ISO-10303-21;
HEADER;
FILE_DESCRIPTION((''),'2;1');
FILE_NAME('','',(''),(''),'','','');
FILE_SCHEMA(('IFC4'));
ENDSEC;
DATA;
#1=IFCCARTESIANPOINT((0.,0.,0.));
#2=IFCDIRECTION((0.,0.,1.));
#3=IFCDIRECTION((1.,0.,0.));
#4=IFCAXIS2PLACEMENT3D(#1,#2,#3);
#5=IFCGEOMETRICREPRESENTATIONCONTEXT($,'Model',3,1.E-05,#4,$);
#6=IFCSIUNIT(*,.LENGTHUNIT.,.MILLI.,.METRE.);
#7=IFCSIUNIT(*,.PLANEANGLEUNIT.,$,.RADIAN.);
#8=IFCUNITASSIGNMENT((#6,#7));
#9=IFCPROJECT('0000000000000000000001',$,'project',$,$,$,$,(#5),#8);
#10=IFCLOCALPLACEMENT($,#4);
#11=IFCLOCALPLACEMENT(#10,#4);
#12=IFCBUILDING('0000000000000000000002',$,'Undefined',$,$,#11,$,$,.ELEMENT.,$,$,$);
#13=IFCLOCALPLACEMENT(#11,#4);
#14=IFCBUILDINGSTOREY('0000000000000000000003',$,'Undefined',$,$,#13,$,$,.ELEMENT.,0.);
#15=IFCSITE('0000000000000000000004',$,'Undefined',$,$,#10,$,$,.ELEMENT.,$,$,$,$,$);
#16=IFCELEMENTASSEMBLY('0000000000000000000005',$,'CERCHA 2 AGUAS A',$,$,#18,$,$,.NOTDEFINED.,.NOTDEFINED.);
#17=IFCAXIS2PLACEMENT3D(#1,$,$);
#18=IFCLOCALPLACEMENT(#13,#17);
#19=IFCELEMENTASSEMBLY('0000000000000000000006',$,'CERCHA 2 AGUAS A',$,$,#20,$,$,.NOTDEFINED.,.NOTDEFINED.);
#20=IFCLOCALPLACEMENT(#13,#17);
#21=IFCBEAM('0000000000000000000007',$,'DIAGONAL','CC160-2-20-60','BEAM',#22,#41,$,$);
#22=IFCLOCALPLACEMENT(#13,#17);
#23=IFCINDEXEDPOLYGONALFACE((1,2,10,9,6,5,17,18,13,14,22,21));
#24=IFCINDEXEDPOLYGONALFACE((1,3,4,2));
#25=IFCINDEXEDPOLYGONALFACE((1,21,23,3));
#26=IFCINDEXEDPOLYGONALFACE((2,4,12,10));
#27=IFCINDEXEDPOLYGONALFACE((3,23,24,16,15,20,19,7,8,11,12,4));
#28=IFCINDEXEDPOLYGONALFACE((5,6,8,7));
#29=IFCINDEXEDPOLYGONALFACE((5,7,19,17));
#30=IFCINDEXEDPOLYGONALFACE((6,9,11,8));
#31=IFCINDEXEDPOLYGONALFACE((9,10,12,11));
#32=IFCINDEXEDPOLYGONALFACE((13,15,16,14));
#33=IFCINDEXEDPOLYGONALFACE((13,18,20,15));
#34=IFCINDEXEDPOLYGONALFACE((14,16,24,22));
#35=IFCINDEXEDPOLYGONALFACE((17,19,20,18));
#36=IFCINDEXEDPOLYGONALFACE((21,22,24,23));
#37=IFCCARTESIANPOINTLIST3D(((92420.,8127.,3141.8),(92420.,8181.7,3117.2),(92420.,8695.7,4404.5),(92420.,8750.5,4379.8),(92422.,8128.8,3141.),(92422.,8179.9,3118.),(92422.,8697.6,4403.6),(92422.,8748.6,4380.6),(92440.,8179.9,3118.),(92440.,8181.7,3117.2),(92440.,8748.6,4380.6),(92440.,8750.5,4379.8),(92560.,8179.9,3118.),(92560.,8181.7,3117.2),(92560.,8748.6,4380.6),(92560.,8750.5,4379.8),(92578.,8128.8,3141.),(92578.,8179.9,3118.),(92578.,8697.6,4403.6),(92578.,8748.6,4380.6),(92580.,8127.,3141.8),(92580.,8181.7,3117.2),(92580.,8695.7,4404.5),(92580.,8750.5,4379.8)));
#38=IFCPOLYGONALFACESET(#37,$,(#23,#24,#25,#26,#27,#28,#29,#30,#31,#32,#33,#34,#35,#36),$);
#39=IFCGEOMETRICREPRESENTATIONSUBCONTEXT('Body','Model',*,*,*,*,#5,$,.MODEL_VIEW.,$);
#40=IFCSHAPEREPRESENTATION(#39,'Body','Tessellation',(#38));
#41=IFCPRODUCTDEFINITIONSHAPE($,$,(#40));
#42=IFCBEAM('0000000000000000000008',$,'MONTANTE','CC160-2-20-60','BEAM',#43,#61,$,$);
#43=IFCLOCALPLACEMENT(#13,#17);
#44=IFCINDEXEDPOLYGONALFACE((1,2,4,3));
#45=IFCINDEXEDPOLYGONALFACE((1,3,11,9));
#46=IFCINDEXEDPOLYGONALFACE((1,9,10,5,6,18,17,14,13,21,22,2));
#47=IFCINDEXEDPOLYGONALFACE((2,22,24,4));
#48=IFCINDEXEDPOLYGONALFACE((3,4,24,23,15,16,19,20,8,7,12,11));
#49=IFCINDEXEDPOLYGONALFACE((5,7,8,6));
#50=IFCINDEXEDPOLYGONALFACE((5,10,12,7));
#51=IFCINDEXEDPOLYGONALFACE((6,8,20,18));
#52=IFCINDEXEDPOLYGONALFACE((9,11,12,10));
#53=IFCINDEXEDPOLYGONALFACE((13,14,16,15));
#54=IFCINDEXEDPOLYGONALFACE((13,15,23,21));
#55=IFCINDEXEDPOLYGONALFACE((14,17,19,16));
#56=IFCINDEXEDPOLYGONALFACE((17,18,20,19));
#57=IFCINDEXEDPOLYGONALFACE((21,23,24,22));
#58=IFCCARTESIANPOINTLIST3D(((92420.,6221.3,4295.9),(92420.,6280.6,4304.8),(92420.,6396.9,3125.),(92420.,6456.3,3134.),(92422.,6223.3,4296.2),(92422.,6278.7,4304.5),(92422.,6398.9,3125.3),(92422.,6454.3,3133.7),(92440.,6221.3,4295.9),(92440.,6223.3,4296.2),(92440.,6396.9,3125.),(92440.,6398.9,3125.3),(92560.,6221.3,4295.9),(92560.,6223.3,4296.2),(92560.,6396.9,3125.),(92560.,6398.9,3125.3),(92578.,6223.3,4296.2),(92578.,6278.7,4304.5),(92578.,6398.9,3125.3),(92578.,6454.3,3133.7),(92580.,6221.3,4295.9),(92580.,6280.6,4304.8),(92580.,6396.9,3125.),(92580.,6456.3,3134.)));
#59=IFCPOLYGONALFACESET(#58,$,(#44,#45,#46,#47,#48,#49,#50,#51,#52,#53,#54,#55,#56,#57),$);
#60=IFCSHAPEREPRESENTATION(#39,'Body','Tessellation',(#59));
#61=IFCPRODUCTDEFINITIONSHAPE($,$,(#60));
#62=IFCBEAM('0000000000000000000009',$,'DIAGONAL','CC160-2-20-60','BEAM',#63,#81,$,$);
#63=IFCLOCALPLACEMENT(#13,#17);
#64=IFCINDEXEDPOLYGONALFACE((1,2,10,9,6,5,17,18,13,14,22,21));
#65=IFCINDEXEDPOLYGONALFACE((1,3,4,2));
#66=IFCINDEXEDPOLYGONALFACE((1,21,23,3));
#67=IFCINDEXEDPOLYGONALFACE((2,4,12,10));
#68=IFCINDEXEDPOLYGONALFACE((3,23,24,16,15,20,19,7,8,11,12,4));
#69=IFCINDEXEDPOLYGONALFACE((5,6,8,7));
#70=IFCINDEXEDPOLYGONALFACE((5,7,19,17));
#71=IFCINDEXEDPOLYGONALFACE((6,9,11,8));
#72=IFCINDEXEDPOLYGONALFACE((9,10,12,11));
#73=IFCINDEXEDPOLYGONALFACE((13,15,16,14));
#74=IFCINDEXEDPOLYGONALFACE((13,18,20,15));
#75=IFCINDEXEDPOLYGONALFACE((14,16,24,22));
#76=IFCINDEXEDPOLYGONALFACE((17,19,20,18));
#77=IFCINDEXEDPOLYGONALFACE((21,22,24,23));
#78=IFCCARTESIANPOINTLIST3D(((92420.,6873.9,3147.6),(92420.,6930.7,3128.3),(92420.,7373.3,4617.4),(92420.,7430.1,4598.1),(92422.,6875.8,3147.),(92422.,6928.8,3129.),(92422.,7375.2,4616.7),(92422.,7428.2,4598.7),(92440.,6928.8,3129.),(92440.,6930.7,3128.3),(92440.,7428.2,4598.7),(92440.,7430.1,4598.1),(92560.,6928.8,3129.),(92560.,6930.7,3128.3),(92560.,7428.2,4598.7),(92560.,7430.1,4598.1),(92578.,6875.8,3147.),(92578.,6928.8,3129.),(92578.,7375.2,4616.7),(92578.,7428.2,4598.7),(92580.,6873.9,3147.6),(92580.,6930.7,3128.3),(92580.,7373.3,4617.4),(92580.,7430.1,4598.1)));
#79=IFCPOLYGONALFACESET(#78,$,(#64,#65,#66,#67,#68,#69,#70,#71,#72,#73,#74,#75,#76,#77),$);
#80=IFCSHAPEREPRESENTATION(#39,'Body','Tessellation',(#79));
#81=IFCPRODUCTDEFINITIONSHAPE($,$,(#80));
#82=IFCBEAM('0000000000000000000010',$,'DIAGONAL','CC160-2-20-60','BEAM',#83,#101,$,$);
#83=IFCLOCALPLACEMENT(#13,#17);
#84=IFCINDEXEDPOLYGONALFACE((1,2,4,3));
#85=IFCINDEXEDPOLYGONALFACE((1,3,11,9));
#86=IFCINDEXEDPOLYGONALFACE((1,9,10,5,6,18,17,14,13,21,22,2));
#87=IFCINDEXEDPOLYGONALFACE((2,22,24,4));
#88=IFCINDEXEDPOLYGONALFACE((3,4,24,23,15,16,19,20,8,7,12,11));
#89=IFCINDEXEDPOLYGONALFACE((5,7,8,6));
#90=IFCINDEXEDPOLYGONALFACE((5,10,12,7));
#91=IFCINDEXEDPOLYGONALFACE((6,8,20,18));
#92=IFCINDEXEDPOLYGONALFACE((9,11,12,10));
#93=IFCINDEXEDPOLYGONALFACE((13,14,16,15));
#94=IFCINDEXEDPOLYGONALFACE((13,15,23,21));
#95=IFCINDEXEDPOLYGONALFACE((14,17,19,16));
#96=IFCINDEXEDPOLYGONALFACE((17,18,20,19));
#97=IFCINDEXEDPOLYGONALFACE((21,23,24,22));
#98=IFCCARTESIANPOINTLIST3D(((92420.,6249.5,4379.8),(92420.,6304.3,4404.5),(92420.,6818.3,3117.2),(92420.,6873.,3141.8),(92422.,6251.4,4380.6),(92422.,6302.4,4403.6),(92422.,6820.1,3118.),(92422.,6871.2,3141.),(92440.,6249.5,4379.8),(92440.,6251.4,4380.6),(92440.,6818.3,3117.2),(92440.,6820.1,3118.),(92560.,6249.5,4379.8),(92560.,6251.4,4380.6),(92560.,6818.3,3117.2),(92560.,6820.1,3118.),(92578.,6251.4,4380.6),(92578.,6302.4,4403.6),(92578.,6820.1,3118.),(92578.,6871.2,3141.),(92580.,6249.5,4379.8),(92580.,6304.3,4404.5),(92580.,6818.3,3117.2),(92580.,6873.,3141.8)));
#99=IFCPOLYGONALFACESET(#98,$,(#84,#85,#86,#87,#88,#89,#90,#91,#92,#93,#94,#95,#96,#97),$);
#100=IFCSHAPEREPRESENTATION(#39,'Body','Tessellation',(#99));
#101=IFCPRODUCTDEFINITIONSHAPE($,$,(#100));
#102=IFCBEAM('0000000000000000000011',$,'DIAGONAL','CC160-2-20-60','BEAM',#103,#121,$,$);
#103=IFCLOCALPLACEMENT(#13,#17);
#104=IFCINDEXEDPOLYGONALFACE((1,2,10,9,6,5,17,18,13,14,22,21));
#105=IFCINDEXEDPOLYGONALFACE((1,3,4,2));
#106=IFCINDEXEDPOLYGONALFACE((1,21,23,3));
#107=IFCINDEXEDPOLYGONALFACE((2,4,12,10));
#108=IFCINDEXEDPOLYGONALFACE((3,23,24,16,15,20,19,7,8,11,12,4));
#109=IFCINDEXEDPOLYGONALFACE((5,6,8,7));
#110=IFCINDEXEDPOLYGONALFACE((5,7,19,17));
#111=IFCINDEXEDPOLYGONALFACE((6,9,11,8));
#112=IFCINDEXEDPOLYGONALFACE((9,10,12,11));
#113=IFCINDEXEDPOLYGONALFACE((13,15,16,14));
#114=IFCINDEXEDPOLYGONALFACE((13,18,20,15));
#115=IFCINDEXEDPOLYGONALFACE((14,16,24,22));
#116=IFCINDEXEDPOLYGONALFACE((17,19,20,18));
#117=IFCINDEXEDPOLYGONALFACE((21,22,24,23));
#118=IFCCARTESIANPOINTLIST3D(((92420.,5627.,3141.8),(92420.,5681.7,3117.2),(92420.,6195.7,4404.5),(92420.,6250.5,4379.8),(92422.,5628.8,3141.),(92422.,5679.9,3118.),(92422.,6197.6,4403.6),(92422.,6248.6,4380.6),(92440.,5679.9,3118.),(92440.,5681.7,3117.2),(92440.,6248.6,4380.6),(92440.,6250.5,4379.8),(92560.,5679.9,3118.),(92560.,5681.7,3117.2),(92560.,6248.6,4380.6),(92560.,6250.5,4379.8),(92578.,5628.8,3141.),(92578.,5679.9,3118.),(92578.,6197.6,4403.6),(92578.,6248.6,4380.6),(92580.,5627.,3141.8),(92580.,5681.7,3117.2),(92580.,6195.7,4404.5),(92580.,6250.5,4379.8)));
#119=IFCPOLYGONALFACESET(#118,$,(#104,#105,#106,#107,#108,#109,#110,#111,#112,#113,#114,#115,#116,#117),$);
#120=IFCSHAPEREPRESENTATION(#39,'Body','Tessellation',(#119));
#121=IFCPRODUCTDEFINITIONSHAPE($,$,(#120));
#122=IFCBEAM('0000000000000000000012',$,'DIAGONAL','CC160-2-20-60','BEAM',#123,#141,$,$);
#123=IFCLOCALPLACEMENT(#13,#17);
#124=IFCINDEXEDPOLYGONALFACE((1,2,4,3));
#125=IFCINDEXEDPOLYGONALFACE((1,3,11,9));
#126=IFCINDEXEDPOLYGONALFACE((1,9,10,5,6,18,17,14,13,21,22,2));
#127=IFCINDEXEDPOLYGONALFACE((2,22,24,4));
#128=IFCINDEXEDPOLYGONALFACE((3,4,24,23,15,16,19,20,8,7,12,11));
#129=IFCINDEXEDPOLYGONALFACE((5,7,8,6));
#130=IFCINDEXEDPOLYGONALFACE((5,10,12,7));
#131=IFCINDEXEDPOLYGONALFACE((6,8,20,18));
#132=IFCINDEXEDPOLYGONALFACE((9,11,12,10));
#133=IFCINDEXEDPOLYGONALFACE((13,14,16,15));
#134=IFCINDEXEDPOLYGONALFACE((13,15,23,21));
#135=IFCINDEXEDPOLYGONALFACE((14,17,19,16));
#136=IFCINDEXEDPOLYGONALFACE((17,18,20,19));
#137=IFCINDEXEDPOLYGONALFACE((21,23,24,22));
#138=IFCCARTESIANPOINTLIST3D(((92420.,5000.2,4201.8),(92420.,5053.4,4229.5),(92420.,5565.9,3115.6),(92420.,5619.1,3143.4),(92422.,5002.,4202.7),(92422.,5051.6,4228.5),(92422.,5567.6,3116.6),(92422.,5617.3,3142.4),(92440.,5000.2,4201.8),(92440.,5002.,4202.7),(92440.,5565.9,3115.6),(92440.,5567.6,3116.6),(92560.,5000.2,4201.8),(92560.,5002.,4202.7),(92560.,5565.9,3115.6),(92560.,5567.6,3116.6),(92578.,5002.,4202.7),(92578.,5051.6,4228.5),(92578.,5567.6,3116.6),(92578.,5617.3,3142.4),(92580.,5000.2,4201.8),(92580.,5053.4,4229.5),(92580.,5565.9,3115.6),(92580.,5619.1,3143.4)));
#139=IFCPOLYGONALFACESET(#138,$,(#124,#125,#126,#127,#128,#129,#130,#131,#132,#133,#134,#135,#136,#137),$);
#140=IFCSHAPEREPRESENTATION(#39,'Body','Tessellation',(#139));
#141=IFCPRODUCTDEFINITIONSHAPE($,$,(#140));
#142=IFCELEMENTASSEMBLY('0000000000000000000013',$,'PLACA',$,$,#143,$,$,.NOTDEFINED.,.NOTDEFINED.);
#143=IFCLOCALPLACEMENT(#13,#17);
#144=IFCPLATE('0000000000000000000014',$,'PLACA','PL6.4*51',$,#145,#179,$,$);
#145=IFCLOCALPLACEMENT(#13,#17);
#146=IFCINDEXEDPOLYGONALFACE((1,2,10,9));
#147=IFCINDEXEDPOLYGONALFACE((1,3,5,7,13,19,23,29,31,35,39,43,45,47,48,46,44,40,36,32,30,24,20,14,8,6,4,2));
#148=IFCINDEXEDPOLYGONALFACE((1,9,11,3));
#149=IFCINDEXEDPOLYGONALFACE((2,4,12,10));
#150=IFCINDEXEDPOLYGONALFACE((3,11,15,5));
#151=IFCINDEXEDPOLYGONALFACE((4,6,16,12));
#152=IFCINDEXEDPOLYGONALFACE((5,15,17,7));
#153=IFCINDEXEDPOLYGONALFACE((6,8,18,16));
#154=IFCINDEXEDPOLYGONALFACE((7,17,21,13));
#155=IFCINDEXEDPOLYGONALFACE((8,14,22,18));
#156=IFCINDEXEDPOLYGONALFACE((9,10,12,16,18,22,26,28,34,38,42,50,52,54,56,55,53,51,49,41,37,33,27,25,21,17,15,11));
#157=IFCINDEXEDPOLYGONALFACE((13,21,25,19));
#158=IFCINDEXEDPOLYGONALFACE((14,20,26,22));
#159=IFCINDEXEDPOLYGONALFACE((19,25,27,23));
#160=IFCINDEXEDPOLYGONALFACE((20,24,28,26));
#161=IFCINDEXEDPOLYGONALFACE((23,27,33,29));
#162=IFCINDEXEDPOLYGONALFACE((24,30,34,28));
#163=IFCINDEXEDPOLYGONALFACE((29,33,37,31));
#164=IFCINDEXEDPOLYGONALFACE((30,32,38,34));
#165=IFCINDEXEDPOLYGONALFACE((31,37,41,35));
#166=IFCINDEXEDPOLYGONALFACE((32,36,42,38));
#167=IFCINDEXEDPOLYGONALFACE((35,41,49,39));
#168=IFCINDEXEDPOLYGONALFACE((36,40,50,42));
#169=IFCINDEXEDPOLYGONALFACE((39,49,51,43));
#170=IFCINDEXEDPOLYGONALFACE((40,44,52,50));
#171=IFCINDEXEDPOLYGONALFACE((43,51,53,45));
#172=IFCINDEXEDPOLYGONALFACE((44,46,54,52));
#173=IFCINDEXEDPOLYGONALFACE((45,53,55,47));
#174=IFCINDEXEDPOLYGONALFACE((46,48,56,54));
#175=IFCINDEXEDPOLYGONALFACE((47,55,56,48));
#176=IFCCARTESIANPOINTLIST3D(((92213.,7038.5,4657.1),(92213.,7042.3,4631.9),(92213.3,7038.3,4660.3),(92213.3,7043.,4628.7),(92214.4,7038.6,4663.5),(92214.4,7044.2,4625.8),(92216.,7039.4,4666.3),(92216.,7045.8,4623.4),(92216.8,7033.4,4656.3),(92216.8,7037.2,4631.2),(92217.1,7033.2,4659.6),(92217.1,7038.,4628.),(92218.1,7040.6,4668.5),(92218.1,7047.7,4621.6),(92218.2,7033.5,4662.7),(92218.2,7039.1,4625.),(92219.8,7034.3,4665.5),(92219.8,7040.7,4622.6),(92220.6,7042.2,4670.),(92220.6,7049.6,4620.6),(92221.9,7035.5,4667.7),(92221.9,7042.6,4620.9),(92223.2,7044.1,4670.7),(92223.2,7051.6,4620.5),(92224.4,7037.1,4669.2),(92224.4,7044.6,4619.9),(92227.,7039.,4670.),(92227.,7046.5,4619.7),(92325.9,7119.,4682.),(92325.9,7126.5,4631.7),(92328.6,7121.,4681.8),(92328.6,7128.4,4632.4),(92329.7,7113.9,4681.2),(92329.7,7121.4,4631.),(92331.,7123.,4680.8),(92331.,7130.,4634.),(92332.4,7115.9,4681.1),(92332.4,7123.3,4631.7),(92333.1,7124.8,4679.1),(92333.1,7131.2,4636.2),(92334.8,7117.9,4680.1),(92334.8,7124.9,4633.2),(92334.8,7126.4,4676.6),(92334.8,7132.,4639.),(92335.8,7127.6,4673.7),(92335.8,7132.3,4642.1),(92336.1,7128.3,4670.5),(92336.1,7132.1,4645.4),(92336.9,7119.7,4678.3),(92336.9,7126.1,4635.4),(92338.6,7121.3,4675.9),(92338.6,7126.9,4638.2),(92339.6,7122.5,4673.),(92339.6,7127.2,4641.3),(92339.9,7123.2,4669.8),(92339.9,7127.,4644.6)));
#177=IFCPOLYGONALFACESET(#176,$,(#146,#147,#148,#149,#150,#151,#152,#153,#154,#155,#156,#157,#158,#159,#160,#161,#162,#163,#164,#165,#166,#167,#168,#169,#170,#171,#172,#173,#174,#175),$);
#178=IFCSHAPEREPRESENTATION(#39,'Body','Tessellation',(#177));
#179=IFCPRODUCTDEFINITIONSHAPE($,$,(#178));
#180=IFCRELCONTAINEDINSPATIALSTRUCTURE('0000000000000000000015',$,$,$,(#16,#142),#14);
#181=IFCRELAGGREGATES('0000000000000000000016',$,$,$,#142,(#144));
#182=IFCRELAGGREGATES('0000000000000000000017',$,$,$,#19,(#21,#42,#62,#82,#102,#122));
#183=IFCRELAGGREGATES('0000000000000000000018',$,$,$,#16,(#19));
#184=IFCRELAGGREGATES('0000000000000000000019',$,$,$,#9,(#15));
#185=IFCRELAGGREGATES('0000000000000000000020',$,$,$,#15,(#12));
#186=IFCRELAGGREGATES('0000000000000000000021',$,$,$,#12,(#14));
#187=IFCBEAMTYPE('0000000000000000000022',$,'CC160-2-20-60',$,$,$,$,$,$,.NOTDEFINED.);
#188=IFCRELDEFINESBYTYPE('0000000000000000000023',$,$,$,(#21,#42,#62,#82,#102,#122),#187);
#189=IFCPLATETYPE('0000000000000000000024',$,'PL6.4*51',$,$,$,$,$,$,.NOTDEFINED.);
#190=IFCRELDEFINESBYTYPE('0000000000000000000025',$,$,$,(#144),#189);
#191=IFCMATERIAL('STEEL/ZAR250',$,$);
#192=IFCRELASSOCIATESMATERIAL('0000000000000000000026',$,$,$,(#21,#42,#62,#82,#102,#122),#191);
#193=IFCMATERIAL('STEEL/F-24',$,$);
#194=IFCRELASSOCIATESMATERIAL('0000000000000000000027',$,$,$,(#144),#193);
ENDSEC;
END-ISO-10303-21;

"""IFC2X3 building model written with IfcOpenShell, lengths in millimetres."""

from ifc_helpers import new_model, si_unit, frame, frame_2d, origin_with_axes, origin_2d_with_axis, place, context, subcontext, project, spatial, polyline, circle_curve, parameter, trimmed, segment, composite_curve, c_section, outline, extrude, material, type_object, element, aggregate, save


model = new_model("IFC2X3")

# Units and contexts
model_context = context("Model", 3, precision=1e-05, world=origin_with_axes())
body_context = subcontext(model_context, "Body", "Model", "MODEL_VIEW")
ifc_project = project(units=[si_unit("LENGTHUNIT", "METRE", prefix="MILLI"), si_unit("PLANEANGLEUNIT", "RADIAN")], contexts=[model_context])

# Site, building, storey
site_placement = place(None, origin_with_axes())
site = spatial("IfcSite", under=ifc_project, at=site_placement, Name="Undefined", CompositionType="ELEMENT")
building_placement = place(site_placement, origin_with_axes())
building = spatial("IfcBuilding", under=site, at=building_placement, Name="Undefined", CompositionType="ELEMENT")
storey_placement = place(building_placement, origin_with_axes())
storey = spatial("IfcBuildingStorey", under=building, at=storey_placement, Name="Undefined", CompositionType="ELEMENT", Elevation=0.0)

# Element assemblies, beams
assembly_1_placement = place(storey_placement, origin_with_axes())
assembly_1 = element("IfcElementAssembly", 1, at=assembly_1_placement, inside=storey, Name="CERCHA 2 AGUAS A", AssemblyPlace="NOTDEFINED", PredefinedType="NOTDEFINED")
assembly_2_placement = place(assembly_1_placement, origin_with_axes())
assembly_2 = element("IfcElementAssembly", 2, at=assembly_2_placement, Name="CERCHA 2 AGUAS A", AssemblyPlace="NOTDEFINED", PredefinedType="NOTDEFINED")
ifc_material_1 = material(Name="STEEL/ZAR250")
beam_type_1 = type_object("IfcBeamType", Name="CC160-2-20-60", PredefinedType="NOTDEFINED")
beam_1_placement = place(assembly_2_placement, frame((92500.0, 8723.1, 4392.1), z_axis=(-1.0, 0.0, 0.0), x_axis=(0.0, -0.410706, -0.911768)))
beam_1 = element("IfcBeam", 3, at=beam_1_placement, type_object=beam_type_1, material=ifc_material_1, Name="DIAGONAL", Description="CC160-2-20-60", ObjectType="BEAM", context=body_context, shape_type="SweptSolid", body=[
    extrude(c_section(Depth=160.0, Width=60.0, WallThickness=2.0, Girth=20.0, at=origin_2d_with_axis()), frame((1384.8, 0.0, 0.0), z_axis=(-1.0, 0.0, 0.0), x_axis=(0.0, -1.0, 0.0)), (0.0, 0.0, 1.0), 1384.8),
])
beam_2_placement = place(assembly_2_placement, frame((92500.0, 6251.0, 4300.4), z_axis=(1.0, 0.0, 0.0), x_axis=(0.0, 0.14834, -0.988936)))
beam_2 = element("IfcBeam", 4, at=beam_2_placement, type_object=beam_type_1, material=ifc_material_1, Name="MONTANTE", Description="CC160-2-20-60", ObjectType="BEAM", context=body_context, shape_type="SweptSolid", body=[
    extrude(c_section(Depth=160.0, Width=60.0, WallThickness=2.0, Girth=20.0, at=origin_2d_with_axis()), frame((1184.0, 0.0, 0.0), z_axis=(-1.0, 0.0, 0.0), x_axis=(0.0, -1.0, 0.0)), (0.0, 0.0, 1.0), 1184.0),
])
beam_3_placement = place(assembly_2_placement, frame((92500.0, 6902.3, 3138.0), z_axis=(1.0, 0.0, 0.0), x_axis=(0.0, 0.321737, 0.946829)))
beam_3 = element("IfcBeam", 5, at=beam_3_placement, type_object=beam_type_1, material=ifc_material_1, Name="DIAGONAL", Description="CC160-2-20-60", ObjectType="BEAM", context=body_context, shape_type="SweptSolid", body=[
    extrude(c_section(Depth=160.0, Width=60.0, WallThickness=2.0, Girth=20.0, at=origin_2d_with_axis()), frame((1552.3, 0.0, 0.0), z_axis=(-1.0, 0.0, 0.0), x_axis=(0.0, -1.0, 0.0)), (0.0, 0.0, 1.0), 1552.3),
])
beam_4_placement = place(assembly_2_placement, frame((92500.0, 6276.9, 4392.1), z_axis=(1.0, 0.0, 0.0), x_axis=(0.0, 0.410706, -0.911768)))
beam_4 = element("IfcBeam", 6, at=beam_4_placement, type_object=beam_type_1, material=ifc_material_1, Name="DIAGONAL", Description="CC160-2-20-60", ObjectType="BEAM", context=body_context, shape_type="SweptSolid", body=[
    extrude(c_section(Depth=160.0, Width=60.0, WallThickness=2.0, Girth=20.0, at=origin_2d_with_axis()), frame((1384.8, 0.0, 0.0), z_axis=(-1.0, 0.0, 0.0), x_axis=(0.0, -1.0, 0.0)), (0.0, 0.0, 1.0), 1384.8),
])
beam_5_placement = place(assembly_2_placement, frame((92500.0, 5654.3, 3129.5), z_axis=(1.0, 0.0, 0.0), x_axis=(0.0, 0.410706, 0.911768)))
beam_5 = element("IfcBeam", 7, at=beam_5_placement, type_object=beam_type_1, material=ifc_material_1, Name="DIAGONAL", Description="CC160-2-20-60", ObjectType="BEAM", context=body_context, shape_type="SweptSolid", body=[
    extrude(c_section(Depth=160.0, Width=60.0, WallThickness=2.0, Girth=20.0, at=origin_2d_with_axis()), frame((1384.8, 0.0, 0.0), z_axis=(-1.0, 0.0, 0.0), x_axis=(0.0, -1.0, 0.0)), (0.0, 0.0, 1.0), 1384.8),
])
beam_6_placement = place(assembly_2_placement, frame((92500.0, 5026.8, 4215.6), z_axis=(1.0, 0.0, 0.0), x_axis=(0.0, 0.461934, -0.886914)))
beam_6 = element("IfcBeam", 8, at=beam_6_placement, type_object=beam_type_1, material=ifc_material_1, Name="DIAGONAL", Description="CC160-2-20-60", ObjectType="BEAM", context=body_context, shape_type="SweptSolid", body=[
    extrude(c_section(Depth=160.0, Width=60.0, WallThickness=2.0, Girth=20.0, at=origin_2d_with_axis()), frame((1224.6, 0.0, 0.0), z_axis=(-1.0, 0.0, 0.0), x_axis=(0.0, -1.0, 0.0)), (0.0, 0.0, 1.0), 1224.6),
])

# Element assembly, plate
assembly_3_placement = place(storey_placement, origin_with_axes())
assembly_3 = element("IfcElementAssembly", 9, at=assembly_3_placement, inside=storey, Name="PLACA", AssemblyPlace="NOTDEFINED", PredefinedType="NOTDEFINED")
ifc_material_2 = material(Name="STEEL/F-24")
plate_type_1 = type_object("IfcPlateType", Name="PL6.4*51", PredefinedType="NOTDEFINED")
plate_1_placement = place(assembly_3_placement, frame((92338.0, 7131.4, 4632.5), z_axis=(0.593392, -0.796008, -0.119399), x_axis=(0.00003, -0.148316, 0.98894)))
plate_1 = element("IfcPlate", 10, at=plate_1_placement, type_object=plate_type_1, material=ifc_material_2, Name="PLACA", Description="PL6.4*51", context=body_context, shape_type="SweptSolid", body=[
    extrude(outline(composite_curve([segment(trimmed(circle_curve(frame_2d((12.7, 12.7), x_axis=(-1.0, 0.0)), 12.7), [parameter(0.0)], [parameter(1.570796)], True, "PARAMETER"), True, "CONTINUOUS"), segment(polyline([(12.7, 0.0), (38.1, 0.0)]), True, "CONTINUOUS"), segment(trimmed(circle_curve(frame_2d((38.1, 12.7), x_axis=(0.0, -1.0)), 12.7), [parameter(0.0)], [parameter(1.570796)], True, "PARAMETER"), True, "CONTINUOUS"), segment(polyline([(50.8, 12.7), (50.8, 140.3)]), True, "CONTINUOUS"), segment(trimmed(circle_curve(frame_2d((38.1, 140.3), x_axis=(1.0, 0.0)), 12.7), [parameter(0.0)], [parameter(1.570796)], True, "PARAMETER"), True, "CONTINUOUS"), segment(polyline([(38.1, 153.0), (12.7, 153.0)]), True, "CONTINUOUS"), segment(trimmed(circle_curve(frame_2d((12.7, 140.3), x_axis=(0.0, 1.0)), 12.7), [parameter(0.0)], [parameter(1.570796)], True, "PARAMETER"), True, "CONTINUOUS"), segment(polyline([(0.0, 140.3), (0.0, 12.7)]), True, "CONTINUOUS")], self_intersect=True)), frame((0.0, 0.0, -3.2), z_axis=(0.0, 0.0, 1.0), x_axis=(1.0, 0.0, 0.0)), (0.0, 0.0, 1.0), 6.4),
])
aggregate(assembly_3, [plate_1])

aggregate(assembly_2, [beam_1, beam_2, beam_3, beam_4, beam_5, beam_6])
aggregate(assembly_1, [assembly_2])

save(model, "model.ifc")
